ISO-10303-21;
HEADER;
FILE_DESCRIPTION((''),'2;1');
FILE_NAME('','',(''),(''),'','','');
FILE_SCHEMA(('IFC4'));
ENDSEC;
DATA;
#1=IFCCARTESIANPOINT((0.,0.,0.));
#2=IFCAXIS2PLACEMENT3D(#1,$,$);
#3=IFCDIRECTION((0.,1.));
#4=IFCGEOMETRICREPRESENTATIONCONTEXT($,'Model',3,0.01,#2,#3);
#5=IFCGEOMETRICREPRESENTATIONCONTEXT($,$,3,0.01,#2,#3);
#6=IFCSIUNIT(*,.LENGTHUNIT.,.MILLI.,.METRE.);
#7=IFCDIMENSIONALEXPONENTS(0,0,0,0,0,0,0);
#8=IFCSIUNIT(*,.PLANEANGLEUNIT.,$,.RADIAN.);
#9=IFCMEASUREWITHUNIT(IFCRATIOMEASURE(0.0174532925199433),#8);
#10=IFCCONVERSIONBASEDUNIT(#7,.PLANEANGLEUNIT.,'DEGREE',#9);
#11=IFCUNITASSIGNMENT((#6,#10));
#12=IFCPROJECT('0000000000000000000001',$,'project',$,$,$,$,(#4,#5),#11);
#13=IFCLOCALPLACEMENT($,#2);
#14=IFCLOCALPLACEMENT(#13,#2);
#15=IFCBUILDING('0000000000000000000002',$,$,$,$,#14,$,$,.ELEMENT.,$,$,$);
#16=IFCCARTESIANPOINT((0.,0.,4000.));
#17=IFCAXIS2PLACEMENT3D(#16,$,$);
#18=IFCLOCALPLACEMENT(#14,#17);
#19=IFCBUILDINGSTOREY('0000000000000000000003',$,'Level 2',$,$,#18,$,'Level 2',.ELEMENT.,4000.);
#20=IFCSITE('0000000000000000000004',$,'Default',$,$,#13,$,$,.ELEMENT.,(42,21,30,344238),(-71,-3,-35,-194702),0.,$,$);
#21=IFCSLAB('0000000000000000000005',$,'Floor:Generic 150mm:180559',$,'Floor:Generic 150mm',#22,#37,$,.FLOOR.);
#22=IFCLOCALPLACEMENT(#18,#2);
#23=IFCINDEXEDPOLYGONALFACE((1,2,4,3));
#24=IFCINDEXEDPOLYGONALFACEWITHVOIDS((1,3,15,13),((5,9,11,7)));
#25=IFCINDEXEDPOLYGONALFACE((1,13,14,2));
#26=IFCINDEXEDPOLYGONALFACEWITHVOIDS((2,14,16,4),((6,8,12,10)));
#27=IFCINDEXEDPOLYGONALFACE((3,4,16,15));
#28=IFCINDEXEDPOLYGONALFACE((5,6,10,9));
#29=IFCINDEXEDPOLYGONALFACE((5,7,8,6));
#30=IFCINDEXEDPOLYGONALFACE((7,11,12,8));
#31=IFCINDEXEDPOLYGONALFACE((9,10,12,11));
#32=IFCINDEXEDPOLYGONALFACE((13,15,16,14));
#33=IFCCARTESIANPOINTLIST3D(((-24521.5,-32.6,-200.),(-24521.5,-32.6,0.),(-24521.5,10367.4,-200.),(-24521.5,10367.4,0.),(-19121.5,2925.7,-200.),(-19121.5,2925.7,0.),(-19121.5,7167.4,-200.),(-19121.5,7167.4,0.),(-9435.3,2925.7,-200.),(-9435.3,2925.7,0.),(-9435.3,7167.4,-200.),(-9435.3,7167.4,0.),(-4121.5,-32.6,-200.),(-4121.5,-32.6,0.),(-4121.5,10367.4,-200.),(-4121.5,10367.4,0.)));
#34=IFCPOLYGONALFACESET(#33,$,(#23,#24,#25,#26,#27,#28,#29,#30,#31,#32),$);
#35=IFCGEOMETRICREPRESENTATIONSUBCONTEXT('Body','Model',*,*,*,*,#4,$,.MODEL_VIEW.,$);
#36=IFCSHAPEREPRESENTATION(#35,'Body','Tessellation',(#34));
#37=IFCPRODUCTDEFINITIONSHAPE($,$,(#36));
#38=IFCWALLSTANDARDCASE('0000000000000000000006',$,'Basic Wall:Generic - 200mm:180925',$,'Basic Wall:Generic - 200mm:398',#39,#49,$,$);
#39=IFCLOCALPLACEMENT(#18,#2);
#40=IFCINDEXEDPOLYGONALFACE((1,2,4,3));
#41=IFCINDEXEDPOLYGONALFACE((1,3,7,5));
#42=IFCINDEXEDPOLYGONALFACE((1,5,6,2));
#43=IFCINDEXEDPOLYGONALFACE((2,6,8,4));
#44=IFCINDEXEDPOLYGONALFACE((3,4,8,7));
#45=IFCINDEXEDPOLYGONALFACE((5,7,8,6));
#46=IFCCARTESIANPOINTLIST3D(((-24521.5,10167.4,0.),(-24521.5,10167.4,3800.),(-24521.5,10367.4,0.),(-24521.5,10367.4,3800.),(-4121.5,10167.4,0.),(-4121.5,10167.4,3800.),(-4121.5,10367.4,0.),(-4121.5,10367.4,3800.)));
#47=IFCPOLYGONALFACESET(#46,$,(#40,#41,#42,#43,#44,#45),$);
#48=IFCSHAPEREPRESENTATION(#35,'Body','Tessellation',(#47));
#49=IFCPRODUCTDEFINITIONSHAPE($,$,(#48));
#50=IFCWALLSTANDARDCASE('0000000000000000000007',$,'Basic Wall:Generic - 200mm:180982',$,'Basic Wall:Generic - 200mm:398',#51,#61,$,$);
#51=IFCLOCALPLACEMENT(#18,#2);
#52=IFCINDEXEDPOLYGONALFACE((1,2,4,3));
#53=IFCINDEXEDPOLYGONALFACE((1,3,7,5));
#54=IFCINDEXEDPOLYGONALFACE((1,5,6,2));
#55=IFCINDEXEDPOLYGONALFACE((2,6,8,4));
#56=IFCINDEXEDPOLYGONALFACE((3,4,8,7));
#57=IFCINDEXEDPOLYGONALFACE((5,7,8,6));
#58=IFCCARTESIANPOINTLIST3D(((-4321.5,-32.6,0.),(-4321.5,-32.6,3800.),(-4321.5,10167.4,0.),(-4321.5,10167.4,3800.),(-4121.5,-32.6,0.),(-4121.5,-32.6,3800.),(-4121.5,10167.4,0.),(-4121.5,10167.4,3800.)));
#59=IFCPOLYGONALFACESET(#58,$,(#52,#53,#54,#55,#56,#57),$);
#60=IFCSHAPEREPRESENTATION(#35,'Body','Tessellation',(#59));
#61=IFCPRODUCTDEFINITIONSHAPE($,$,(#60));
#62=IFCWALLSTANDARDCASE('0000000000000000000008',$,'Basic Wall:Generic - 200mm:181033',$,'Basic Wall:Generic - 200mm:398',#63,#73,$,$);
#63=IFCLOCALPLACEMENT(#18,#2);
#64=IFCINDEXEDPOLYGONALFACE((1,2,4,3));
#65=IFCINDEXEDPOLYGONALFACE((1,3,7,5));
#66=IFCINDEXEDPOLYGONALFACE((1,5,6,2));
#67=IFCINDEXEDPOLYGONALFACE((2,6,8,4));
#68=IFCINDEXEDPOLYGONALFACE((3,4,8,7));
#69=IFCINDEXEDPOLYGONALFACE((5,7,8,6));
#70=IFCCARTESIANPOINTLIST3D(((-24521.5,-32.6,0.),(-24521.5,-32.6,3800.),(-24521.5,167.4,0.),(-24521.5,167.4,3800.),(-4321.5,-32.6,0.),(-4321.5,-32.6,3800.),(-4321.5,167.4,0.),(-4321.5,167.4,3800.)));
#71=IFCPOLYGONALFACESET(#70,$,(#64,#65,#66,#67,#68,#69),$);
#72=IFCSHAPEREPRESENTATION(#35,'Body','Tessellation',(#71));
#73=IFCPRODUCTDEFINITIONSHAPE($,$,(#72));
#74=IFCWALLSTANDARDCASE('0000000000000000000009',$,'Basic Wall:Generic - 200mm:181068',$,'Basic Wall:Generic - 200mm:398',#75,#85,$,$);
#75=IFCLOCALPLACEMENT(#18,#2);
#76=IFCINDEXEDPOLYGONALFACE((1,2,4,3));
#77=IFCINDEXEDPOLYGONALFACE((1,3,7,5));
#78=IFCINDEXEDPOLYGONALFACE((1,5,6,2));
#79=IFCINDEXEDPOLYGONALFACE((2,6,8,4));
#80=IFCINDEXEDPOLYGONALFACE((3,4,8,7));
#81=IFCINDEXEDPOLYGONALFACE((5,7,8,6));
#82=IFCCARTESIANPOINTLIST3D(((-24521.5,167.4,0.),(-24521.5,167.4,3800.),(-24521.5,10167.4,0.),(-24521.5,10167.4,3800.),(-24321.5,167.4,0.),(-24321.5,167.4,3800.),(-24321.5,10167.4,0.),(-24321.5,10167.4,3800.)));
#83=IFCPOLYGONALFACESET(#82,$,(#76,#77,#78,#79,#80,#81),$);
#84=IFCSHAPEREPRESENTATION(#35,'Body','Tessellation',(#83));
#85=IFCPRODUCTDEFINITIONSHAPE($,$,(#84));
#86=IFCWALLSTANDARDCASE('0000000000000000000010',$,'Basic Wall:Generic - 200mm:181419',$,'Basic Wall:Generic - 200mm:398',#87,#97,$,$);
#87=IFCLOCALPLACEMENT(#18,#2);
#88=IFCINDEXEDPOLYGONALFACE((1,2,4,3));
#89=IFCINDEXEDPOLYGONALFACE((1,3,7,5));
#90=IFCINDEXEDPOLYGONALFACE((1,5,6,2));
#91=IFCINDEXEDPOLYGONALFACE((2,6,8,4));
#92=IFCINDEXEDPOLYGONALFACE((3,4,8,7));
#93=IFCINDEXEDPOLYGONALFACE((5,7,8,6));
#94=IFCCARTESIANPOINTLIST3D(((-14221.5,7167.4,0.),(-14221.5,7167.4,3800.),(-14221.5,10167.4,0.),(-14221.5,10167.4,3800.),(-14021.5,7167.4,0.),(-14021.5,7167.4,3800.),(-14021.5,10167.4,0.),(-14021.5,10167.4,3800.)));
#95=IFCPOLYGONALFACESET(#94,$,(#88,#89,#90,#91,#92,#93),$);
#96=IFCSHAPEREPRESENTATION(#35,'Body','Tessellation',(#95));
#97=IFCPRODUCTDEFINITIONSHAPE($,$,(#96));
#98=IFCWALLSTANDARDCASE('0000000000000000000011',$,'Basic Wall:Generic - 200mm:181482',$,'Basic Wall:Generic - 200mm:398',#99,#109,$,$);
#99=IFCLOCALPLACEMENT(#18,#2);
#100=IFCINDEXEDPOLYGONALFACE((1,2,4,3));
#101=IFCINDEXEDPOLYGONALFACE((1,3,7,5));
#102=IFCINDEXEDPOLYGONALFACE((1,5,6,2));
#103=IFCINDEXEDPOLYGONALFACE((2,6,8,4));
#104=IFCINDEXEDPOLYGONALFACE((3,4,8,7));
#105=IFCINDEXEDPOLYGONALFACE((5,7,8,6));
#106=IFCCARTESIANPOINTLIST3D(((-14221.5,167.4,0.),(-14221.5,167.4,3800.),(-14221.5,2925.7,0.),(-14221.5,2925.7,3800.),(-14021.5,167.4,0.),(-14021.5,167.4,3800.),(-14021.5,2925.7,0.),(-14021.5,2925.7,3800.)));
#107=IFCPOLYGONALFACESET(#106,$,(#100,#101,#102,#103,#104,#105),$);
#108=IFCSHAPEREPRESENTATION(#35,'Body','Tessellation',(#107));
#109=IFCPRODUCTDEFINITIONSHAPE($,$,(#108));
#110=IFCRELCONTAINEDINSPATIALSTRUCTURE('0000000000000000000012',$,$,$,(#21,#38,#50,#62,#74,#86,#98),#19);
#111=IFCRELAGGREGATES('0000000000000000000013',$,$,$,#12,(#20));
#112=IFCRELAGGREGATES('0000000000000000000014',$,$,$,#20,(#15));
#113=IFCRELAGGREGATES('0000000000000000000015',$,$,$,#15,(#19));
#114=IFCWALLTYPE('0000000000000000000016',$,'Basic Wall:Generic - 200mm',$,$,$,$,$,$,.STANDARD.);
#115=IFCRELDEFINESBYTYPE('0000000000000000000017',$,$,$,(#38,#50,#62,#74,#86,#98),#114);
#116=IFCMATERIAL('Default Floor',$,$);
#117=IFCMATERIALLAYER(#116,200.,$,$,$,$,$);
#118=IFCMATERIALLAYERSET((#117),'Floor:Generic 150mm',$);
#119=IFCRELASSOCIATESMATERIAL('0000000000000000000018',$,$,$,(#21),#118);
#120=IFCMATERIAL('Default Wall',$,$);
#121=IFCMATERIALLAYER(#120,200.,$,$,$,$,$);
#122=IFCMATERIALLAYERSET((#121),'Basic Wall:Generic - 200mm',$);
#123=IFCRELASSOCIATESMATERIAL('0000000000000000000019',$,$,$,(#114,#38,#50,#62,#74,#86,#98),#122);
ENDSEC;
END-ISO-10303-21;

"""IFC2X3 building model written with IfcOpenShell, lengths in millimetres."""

from ifc_helpers import new_model, entity, si_unit, converted_unit, direction, frame, frame_2d, origin, origin_2d_with_axis, place, context, subcontext, project, spatial, rectangle, extrude, material, layer, layer_set, layer_usage, type_object, element, save


model = new_model("IFC2X3")

# Units and contexts
model_context = context("Model", 3, precision=0.01, world=origin(), true_north=direction((0.0, 1.0)))
context_of_model = context(None, 3, precision=0.01, world=origin(), true_north=direction((0.0, 1.0)))
body_context = subcontext(model_context, "Body", "Model", "MODEL_VIEW")
ifc_project = project(units=[si_unit("LENGTHUNIT", "METRE", prefix="MILLI"), converted_unit("PLANEANGLEUNIT", "DEGREE", entity("IfcRatioMeasure", 0.0174532925199433), si_unit("PLANEANGLEUNIT", "RADIAN"), dimensions=[0, 0, 0, 0, 0, 0, 0])], contexts=[model_context, context_of_model])

# Site, building, storey
site_placement = place(None, origin())
site = spatial("IfcSite", under=ifc_project, at=site_placement, Name="Default", CompositionType="ELEMENT", RefLatitude=(42, 21, 30, 344238), RefLongitude=(-71, -3, -35, -194702), RefElevation=0.0)
building_placement = place(site_placement, origin())
building = spatial("IfcBuilding", under=site, at=building_placement, CompositionType="ELEMENT")
storey_placement = place(building_placement, frame((0.0, 0.0, 4000.0)))
storey = spatial("IfcBuildingStorey", under=building, at=storey_placement, Name="Level 2", LongName="Level 2", CompositionType="ELEMENT", Elevation=4000.0)

# Slab, opening
ifc_material_1 = material(Name="Default Floor")
ifc_layer_1 = layer(ifc_material_1, 200.0)
ifc_layer_set_1 = layer_set([ifc_layer_1], Name="Floor:Generic 150mm")
ifc_layer_usage_1 = layer_usage(ifc_layer_set_1, "AXIS3", "POSITIVE", 0.0)
slab_placement = place(storey_placement, frame((-24521.5, -32.6, -200.0)))
slab = element("IfcSlab", 1, at=slab_placement, inside=storey, material=ifc_layer_usage_1, Name="Floor:Generic 150mm:180559", ObjectType="Floor:Generic 150mm", PredefinedType="FLOOR", context=body_context, shape_type="SweptSolid", body=[
    extrude(rectangle(XDim=10400.0, YDim=20400.0, at=frame_2d((0.0, 0.0), x_axis=(0.0, -1.0))), frame((10200.0, 5200.0, 200.0), z_axis=(0.0, 0.0, -1.0), x_axis=(-1.0, 0.0, 0.0)), (0.0, 0.0, 1.0), 200.0),
])
opening_placement = place(slab_placement, frame((10243.1, 5079.1, 200.0)))
element("IfcOpeningElement", 2, at=opening_placement, cuts=slab, ObjectType="Opening", context=body_context, shape_type="SweptSolid", body=[
    extrude(rectangle(XDim=4241.7, YDim=9686.2, at=origin_2d_with_axis()), frame((0.0, 0.0, 0.0), z_axis=(0.0, 0.0, -1.0), x_axis=(0.0, -1.0, 0.0)), (0.0, 0.0, 1.0), 200.0),
])

# Walls
ifc_material_2 = material(Name="Default Wall")
ifc_layer_2 = layer(ifc_material_2, 200.0)
ifc_layer_set_2 = layer_set([ifc_layer_2], Name="Basic Wall:Generic - 200mm")
ifc_layer_usage_2 = layer_usage(ifc_layer_set_2, "AXIS2", "NEGATIVE", 100.0)
wall_type = type_object("IfcWallType", Name="Basic Wall:Generic - 200mm", PredefinedType="STANDARD", material=ifc_layer_set_2)
wall_1_placement = place(storey_placement, frame((-24521.5, 10267.4, 0.0)))
element("IfcWallStandardCase", 3, at=wall_1_placement, inside=storey, type_object=wall_type, material=ifc_layer_usage_2, Name="Basic Wall:Generic - 200mm:180925", ObjectType="Basic Wall:Generic - 200mm:398", context=body_context, shape_type="SweptSolid", body=[
    extrude(rectangle(XDim=20400.0, YDim=200.0, at=frame_2d((10200.0, 0.0), x_axis=(-1.0, 0.0))), origin(), (0.0, 0.0, 1.0), 3800.0),
])
ifc_layer_usage_3 = layer_usage(ifc_layer_set_2, "AXIS2", "NEGATIVE", 100.0)
wall_2_placement = place(storey_placement, frame((-4221.5, 10167.4, 0.0), z_axis=(0.0, 0.0, 1.0), x_axis=(0.0, -1.0, 0.0)))
element("IfcWallStandardCase", 4, at=wall_2_placement, inside=storey, type_object=wall_type, material=ifc_layer_usage_3, Name="Basic Wall:Generic - 200mm:180982", ObjectType="Basic Wall:Generic - 200mm:398", context=body_context, shape_type="SweptSolid", body=[
    extrude(rectangle(XDim=10200.0, YDim=200.0, at=frame_2d((5100.0, 0.0), x_axis=(-1.0, 0.0))), origin(), (0.0, 0.0, 1.0), 3800.0),
])
ifc_layer_usage_4 = layer_usage(ifc_layer_set_2, "AXIS2", "NEGATIVE", 100.0)
wall_3_placement = place(storey_placement, frame((-4321.5, 67.4, 0.0), z_axis=(0.0, 0.0, 1.0), x_axis=(-1.0, 0.0, 0.0)))
element("IfcWallStandardCase", 5, at=wall_3_placement, inside=storey, type_object=wall_type, material=ifc_layer_usage_4, Name="Basic Wall:Generic - 200mm:181033", ObjectType="Basic Wall:Generic - 200mm:398", context=body_context, shape_type="SweptSolid", body=[
    extrude(rectangle(XDim=20200.0, YDim=200.0, at=frame_2d((10100.0, 0.0), x_axis=(-1.0, 0.0))), origin(), (0.0, 0.0, 1.0), 3800.0),
])
ifc_layer_usage_5 = layer_usage(ifc_layer_set_2, "AXIS2", "NEGATIVE", 100.0)
wall_4_placement = place(storey_placement, frame((-24421.5, 167.4, 0.0), z_axis=(0.0, 0.0, 1.0), x_axis=(0.0, 1.0, 0.0)))
element("IfcWallStandardCase", 6, at=wall_4_placement, inside=storey, type_object=wall_type, material=ifc_layer_usage_5, Name="Basic Wall:Generic - 200mm:181068", ObjectType="Basic Wall:Generic - 200mm:398", context=body_context, shape_type="SweptSolid", body=[
    extrude(rectangle(XDim=10000.0, YDim=200.0, at=frame_2d((5000.0, 0.0), x_axis=(-1.0, 0.0))), origin(), (0.0, 0.0, 1.0), 3800.0),
])
ifc_layer_usage_6 = layer_usage(ifc_layer_set_2, "AXIS2", "NEGATIVE", 100.0)
wall_5_placement = place(storey_placement, frame((-14121.5, 10167.4, 0.0), z_axis=(0.0, 0.0, 1.0), x_axis=(0.0, -1.0, 0.0)))
element("IfcWallStandardCase", 7, at=wall_5_placement, inside=storey, type_object=wall_type, material=ifc_layer_usage_6, Name="Basic Wall:Generic - 200mm:181419", ObjectType="Basic Wall:Generic - 200mm:398", context=body_context, shape_type="SweptSolid", body=[
    extrude(rectangle(XDim=3000.0, YDim=200.0, at=frame_2d((1500.0, 0.0), x_axis=(-1.0, 0.0))), origin(), (0.0, 0.0, 1.0), 3800.0),
])
ifc_layer_usage_7 = layer_usage(ifc_layer_set_2, "AXIS2", "NEGATIVE", 100.0)
wall_6_placement = place(storey_placement, frame((-14121.5, 2925.7, 0.0), z_axis=(0.0, 0.0, 1.0), x_axis=(0.0, -1.0, 0.0)))
element("IfcWallStandardCase", 8, at=wall_6_placement, inside=storey, type_object=wall_type, material=ifc_layer_usage_7, Name="Basic Wall:Generic - 200mm:181482", ObjectType="Basic Wall:Generic - 200mm:398", context=body_context, shape_type="SweptSolid", body=[
    extrude(rectangle(XDim=2758.3, YDim=200.0, at=frame_2d((1379.1, 0.0), x_axis=(-1.0, 0.0))), origin(), (0.0, 0.0, 1.0), 3800.0),
])

save(model, "model.ifc")
